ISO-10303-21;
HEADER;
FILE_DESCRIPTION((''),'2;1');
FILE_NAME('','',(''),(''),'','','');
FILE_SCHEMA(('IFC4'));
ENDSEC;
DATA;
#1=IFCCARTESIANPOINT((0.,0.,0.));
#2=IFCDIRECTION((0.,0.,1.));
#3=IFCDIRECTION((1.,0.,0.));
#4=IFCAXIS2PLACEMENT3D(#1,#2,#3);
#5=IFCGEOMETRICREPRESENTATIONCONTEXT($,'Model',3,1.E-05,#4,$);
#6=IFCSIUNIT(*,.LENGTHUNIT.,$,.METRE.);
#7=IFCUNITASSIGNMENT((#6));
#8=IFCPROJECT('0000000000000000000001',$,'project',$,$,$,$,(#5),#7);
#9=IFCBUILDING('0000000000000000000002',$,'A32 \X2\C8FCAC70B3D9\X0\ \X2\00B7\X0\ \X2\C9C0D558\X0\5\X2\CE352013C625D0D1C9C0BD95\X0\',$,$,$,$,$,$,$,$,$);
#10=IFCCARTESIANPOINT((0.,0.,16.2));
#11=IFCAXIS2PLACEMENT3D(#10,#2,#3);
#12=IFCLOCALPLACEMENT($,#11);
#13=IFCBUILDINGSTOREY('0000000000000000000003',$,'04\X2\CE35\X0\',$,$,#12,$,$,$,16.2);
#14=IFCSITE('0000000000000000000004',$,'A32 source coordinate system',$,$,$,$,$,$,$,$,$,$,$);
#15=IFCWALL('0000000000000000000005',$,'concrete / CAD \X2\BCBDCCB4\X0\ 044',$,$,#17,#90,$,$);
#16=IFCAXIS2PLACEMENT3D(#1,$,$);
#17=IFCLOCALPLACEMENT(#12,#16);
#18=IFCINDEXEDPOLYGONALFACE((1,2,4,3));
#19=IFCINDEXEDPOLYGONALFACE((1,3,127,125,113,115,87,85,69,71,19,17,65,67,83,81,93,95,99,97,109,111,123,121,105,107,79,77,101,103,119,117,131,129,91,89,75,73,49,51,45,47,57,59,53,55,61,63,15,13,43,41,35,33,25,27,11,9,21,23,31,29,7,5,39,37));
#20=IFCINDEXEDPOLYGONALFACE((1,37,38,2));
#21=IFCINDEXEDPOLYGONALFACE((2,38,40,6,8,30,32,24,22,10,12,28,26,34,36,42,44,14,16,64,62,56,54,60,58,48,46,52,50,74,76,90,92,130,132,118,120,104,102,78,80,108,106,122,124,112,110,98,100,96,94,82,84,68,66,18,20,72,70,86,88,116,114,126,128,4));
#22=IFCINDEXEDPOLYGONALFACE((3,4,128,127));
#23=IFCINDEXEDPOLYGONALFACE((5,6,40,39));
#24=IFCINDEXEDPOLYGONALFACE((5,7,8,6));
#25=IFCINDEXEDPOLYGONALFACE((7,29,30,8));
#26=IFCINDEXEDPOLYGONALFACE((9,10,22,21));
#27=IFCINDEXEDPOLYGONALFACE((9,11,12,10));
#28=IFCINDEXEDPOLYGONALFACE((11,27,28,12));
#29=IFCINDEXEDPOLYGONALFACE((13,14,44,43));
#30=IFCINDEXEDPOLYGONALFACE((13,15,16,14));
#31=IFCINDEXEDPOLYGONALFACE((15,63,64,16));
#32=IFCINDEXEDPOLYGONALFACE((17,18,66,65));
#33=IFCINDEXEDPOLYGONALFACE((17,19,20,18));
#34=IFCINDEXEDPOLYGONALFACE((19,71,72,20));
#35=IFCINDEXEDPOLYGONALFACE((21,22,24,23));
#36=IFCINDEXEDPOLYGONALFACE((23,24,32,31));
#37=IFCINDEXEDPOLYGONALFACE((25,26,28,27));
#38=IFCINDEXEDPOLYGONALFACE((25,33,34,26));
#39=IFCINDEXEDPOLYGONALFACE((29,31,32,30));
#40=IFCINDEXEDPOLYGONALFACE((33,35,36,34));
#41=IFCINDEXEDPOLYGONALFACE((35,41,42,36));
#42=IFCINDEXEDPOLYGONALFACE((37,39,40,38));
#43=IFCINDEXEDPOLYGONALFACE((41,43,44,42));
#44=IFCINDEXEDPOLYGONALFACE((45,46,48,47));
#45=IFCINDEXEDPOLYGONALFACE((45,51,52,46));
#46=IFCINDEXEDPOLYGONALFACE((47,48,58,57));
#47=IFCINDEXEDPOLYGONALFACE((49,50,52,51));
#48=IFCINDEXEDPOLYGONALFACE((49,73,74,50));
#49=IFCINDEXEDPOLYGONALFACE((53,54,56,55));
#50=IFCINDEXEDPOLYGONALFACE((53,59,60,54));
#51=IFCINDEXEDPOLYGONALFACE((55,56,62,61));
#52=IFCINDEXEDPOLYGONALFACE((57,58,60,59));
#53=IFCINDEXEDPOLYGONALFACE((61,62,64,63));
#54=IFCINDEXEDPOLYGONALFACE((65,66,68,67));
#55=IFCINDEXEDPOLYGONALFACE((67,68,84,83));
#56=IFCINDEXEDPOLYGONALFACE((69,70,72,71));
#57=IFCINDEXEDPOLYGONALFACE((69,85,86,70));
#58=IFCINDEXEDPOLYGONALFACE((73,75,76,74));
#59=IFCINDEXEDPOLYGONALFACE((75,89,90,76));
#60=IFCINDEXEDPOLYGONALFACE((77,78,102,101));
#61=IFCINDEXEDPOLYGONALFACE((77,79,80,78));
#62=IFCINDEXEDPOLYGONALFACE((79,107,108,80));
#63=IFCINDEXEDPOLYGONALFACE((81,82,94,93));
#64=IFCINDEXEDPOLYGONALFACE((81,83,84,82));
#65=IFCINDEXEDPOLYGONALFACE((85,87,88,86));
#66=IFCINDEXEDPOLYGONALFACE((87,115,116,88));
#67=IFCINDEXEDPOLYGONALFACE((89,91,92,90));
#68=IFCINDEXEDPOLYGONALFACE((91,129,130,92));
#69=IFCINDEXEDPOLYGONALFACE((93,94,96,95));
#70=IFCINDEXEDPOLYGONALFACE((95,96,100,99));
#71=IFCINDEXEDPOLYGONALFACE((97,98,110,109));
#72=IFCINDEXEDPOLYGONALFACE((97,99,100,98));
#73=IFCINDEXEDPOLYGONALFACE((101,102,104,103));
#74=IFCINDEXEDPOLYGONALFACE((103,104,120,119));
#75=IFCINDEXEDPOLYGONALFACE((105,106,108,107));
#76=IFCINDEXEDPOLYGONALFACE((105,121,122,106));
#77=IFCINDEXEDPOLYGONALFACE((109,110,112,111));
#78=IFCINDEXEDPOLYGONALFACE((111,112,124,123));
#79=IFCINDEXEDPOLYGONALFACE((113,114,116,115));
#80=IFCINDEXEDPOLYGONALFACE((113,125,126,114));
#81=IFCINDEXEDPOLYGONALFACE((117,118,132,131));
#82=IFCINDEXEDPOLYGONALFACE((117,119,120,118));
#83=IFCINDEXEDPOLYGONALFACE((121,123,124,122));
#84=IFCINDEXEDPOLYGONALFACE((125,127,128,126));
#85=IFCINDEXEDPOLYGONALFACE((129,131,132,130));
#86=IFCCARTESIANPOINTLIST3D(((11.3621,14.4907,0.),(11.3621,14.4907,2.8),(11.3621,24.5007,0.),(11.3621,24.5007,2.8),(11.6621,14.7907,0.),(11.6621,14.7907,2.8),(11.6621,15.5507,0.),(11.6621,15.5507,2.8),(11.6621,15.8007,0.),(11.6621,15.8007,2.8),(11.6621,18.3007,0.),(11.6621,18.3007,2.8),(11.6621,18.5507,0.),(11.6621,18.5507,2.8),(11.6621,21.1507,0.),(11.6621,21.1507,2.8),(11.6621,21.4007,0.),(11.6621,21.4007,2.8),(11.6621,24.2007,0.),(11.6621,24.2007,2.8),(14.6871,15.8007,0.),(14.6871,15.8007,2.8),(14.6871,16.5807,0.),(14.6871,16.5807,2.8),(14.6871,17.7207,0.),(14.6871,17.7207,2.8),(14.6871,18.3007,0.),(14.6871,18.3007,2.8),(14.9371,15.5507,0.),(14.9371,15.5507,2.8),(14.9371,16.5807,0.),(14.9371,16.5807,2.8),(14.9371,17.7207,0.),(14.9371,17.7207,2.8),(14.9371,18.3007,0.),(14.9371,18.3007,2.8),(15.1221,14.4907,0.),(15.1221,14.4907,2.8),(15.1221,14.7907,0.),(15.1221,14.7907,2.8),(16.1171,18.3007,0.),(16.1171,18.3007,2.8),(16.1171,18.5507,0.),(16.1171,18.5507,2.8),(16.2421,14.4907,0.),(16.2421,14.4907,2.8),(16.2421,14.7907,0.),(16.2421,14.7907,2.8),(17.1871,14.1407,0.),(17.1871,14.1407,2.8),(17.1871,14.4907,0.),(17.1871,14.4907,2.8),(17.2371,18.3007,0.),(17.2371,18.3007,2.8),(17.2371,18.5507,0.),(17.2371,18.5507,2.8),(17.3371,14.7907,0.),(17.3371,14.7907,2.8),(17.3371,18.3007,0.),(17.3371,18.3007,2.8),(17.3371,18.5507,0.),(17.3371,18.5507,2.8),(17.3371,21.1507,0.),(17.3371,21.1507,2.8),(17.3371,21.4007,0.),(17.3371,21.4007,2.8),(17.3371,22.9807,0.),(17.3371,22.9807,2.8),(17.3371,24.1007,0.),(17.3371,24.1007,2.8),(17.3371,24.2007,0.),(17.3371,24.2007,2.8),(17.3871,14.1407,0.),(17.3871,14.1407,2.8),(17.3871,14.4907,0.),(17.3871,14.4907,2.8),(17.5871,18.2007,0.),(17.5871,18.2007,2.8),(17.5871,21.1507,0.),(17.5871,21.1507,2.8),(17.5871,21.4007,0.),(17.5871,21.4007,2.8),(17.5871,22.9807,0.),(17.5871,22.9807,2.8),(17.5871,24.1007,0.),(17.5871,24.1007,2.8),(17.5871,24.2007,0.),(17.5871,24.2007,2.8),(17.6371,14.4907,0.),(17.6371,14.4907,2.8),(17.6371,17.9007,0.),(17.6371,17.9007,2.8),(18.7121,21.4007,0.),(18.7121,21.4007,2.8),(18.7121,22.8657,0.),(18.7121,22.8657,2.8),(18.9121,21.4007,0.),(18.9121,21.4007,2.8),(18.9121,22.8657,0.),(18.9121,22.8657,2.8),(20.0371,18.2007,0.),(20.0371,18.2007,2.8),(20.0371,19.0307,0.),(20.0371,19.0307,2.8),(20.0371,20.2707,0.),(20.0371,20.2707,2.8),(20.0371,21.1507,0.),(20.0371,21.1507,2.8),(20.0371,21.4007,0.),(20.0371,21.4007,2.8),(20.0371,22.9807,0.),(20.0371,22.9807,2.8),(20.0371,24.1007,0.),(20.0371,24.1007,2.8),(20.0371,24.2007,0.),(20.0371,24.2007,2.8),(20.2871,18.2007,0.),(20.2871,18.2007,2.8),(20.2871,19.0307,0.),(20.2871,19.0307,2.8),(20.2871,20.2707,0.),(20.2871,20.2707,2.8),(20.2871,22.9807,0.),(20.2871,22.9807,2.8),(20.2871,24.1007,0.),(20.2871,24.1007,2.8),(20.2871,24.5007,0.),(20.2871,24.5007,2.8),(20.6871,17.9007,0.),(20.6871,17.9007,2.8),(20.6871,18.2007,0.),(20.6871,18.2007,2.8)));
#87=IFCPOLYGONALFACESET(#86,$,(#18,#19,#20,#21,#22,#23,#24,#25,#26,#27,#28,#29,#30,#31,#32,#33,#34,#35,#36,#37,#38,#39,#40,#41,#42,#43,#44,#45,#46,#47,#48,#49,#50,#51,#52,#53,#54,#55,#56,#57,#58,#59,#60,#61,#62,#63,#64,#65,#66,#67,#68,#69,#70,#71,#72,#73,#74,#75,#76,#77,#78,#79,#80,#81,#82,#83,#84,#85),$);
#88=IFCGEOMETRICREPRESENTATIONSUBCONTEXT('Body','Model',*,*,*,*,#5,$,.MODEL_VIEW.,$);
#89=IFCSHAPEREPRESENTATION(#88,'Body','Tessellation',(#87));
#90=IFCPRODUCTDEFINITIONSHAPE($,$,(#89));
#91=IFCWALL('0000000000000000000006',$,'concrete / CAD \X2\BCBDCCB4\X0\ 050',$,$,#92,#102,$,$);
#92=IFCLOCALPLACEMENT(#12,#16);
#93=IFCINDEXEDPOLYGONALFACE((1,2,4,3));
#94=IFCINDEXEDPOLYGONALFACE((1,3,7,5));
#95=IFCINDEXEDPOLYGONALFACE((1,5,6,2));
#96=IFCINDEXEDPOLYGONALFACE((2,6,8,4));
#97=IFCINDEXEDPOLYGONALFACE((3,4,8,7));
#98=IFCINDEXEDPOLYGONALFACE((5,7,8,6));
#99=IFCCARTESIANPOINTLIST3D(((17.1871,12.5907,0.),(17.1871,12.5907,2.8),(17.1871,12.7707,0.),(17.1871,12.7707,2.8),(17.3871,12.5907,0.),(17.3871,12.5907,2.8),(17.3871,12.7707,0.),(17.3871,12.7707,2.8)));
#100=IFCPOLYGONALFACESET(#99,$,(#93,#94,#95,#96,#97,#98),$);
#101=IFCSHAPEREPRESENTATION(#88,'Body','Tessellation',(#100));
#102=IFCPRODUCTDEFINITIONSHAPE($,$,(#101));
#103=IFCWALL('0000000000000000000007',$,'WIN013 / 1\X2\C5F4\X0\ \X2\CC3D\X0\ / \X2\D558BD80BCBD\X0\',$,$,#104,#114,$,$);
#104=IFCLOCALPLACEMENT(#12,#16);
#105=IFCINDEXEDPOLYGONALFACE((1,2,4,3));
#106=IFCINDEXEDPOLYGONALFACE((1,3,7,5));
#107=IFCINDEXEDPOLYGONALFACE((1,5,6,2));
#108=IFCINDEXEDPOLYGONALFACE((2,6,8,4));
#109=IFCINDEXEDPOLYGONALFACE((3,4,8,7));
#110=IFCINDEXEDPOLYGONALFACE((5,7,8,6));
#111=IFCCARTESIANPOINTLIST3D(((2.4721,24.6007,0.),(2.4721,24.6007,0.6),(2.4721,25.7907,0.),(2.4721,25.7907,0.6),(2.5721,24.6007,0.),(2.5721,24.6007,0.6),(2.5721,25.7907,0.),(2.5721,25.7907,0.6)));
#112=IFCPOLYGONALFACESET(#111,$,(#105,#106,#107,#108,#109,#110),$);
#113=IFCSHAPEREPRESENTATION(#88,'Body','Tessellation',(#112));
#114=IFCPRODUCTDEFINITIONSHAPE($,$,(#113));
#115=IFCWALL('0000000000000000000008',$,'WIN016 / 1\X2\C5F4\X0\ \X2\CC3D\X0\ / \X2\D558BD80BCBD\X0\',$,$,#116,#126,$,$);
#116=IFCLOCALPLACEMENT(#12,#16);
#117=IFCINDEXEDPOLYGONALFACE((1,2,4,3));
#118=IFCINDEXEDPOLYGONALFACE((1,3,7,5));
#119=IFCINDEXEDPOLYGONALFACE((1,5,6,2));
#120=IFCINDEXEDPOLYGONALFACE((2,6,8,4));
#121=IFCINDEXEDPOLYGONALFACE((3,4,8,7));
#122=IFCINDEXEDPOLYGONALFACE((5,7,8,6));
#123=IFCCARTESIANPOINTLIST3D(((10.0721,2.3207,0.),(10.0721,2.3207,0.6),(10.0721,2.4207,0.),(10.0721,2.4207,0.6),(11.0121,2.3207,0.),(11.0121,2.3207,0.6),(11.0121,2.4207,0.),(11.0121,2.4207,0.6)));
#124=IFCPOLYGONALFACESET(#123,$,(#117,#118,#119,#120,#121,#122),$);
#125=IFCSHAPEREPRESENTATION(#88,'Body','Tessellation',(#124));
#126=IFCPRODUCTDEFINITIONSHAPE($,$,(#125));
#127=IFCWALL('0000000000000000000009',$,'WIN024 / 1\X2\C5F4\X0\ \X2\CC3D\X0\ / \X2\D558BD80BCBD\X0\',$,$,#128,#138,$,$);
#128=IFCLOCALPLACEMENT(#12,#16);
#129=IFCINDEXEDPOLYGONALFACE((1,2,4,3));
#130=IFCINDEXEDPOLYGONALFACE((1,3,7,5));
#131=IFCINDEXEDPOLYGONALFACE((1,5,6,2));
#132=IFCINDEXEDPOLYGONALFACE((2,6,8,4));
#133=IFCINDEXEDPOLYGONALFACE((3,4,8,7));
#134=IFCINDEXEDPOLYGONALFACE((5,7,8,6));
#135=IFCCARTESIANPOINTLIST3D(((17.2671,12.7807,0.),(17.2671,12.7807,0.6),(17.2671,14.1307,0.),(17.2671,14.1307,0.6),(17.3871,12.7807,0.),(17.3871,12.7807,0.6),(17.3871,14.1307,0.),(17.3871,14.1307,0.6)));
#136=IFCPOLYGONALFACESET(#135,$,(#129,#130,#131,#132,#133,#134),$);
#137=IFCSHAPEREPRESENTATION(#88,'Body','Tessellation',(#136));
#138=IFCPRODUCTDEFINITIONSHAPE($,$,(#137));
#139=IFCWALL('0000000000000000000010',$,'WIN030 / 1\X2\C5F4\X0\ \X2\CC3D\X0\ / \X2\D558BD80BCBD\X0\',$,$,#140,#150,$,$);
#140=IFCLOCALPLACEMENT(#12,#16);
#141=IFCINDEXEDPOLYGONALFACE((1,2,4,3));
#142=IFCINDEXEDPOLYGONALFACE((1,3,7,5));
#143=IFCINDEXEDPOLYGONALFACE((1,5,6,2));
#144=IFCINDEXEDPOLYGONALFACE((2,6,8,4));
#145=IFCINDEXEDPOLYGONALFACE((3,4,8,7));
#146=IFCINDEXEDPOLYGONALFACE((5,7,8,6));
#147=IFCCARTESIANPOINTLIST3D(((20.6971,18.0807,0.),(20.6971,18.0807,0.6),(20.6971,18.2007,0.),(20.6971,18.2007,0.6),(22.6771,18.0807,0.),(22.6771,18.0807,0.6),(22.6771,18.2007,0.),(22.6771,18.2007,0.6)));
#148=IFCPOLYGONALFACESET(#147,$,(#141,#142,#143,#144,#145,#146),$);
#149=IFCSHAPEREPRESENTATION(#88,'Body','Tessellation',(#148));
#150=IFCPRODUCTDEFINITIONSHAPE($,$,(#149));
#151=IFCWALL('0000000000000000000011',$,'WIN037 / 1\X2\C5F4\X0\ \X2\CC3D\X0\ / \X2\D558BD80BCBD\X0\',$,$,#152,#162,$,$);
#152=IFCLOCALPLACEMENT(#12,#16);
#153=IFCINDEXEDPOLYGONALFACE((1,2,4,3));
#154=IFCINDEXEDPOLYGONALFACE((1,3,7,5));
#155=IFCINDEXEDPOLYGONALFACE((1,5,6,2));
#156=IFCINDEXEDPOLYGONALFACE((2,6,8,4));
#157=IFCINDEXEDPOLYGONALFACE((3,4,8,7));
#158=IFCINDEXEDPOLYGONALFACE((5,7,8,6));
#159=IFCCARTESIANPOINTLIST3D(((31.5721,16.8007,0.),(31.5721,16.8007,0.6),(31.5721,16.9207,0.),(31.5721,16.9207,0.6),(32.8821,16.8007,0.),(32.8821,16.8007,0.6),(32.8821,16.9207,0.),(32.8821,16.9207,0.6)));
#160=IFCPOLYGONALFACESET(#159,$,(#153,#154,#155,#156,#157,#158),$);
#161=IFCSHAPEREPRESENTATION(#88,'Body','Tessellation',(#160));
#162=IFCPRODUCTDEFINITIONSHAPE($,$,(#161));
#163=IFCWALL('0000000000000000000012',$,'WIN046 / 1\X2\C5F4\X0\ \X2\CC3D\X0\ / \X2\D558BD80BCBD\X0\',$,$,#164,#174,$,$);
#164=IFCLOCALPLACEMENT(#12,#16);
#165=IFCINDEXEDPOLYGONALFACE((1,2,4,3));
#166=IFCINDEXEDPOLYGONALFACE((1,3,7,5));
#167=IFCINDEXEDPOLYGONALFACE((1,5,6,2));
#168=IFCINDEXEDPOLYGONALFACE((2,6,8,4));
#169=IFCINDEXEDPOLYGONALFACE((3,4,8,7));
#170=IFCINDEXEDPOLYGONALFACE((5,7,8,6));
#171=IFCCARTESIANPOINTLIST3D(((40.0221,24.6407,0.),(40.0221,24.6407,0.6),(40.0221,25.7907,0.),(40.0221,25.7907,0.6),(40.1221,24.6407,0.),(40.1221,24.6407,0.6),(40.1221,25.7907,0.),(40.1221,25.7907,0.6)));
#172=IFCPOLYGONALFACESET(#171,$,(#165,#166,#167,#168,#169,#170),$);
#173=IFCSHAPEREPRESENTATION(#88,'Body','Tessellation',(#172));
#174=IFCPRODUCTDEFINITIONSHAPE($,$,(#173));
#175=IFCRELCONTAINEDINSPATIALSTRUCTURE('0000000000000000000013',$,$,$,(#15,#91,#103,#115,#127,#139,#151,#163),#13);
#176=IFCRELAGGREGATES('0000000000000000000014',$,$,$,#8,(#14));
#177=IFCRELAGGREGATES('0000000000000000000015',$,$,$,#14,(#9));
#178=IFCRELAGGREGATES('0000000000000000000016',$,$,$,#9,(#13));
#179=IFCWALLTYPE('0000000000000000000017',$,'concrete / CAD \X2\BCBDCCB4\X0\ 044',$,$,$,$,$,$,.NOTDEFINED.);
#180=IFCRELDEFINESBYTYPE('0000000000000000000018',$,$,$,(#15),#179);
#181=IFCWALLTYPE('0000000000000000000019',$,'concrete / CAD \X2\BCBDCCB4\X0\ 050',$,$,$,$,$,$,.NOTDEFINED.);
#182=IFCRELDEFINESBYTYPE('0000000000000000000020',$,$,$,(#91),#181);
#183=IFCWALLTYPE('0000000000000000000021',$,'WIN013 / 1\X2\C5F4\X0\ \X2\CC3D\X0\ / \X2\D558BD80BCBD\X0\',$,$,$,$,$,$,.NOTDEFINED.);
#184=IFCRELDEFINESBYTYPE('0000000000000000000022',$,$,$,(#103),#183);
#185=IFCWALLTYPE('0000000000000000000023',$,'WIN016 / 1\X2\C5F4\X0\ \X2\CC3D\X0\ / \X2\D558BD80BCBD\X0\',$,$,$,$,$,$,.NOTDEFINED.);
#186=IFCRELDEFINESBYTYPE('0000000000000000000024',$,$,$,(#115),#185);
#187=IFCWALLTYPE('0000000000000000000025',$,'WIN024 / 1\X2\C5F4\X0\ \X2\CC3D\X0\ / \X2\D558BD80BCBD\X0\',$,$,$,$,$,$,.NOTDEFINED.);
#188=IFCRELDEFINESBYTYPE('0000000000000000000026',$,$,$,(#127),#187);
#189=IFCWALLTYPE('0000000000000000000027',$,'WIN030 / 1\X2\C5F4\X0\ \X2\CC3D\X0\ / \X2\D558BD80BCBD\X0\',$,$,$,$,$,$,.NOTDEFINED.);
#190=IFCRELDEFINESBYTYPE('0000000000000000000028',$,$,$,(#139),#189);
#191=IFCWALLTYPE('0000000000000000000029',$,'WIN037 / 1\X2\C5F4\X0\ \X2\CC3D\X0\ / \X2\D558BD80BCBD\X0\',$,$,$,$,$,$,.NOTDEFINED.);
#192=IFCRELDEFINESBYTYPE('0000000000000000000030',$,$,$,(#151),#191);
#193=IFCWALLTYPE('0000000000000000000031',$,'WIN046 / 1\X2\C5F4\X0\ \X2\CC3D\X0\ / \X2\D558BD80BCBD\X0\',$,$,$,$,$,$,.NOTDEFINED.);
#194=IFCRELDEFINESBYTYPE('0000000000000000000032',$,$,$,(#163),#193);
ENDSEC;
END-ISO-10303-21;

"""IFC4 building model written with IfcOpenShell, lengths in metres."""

from ifc_helpers import new_model, si_unit, frame, origin, origin_with_axes, place, context, subcontext, project, spatial, polyline, outline, extrude, source, transform, mapped, type_object, type_shapes, element, save


model = new_model("IFC4")

# Units and contexts
model_context = context("Model", 3, precision=1e-05, world=origin_with_axes())
body_context = subcontext(model_context, "Body", "Model", "MODEL_VIEW")
ifc_project = project(units=[si_unit("LENGTHUNIT", "METRE")], contexts=[model_context])

# Site, building, storey
site = spatial("IfcSite", under=ifc_project, Name="A32 source coordinate system")
building = spatial("IfcBuilding", under=site, Name="A32 주거동 · 지하5층–옥탑지붕")
storey_placement = place(None, frame((0.0, 0.0, 16.2), z_axis=(0.0, 0.0, 1.0), x_axis=(1.0, 0.0, 0.0)))
storey = spatial("IfcBuildingStorey", under=building, at=storey_placement, Name="04층", Elevation=16.2)

# Walls
wall_type_1 = type_object("IfcWallType", Name="concrete / CAD 벽체 044", PredefinedType="NOTDEFINED")
shared_shape_1 = source(origin(), body_context, "Body", "SweptSolid", [
    extrude(outline(polyline([(17.3371, 22.9807), (17.5871, 22.9807), (17.5871, 21.4007), (18.7121, 21.4007), (18.7121, 22.8657), (18.9121, 22.8657), (18.9121, 21.4007), (20.0371, 21.4007), (20.0371, 22.9807), (20.2871, 22.9807), (20.2871, 20.2707), (20.0371, 20.2707), (20.0371, 21.1507), (17.5871, 21.1507), (17.5871, 18.2007), (20.0371, 18.2007), (20.0371, 19.0307), (20.2871, 19.0307), (20.2871, 18.2007), (20.6871, 18.2007), (20.6871, 17.9007), (17.6371, 17.9007), (17.6371, 14.4907), (17.3871, 14.4907), (17.3871, 14.1407), (17.1871, 14.1407), (17.1871, 14.4907), (16.2421, 14.4907), (16.2421, 14.7907), (17.3371, 14.7907), (17.3371, 18.3007), (17.2371, 18.3007), (17.2371, 18.5507), (17.3371, 18.5507), (17.3371, 21.1507), (11.6621, 21.1507), (11.6621, 18.5507), (16.1171, 18.5507), (16.1171, 18.3007), (14.9371, 18.3007), (14.9371, 17.7207), (14.6871, 17.7207), (14.6871, 18.3007), (11.6621, 18.3007), (11.6621, 15.8007), (14.6871, 15.8007), (14.6871, 16.5807), (14.9371, 16.5807), (14.9371, 15.5507), (11.6621, 15.5507), (11.6621, 14.7907), (15.1221, 14.7907), (15.1221, 14.4907), (11.3621, 14.4907), (11.3621, 24.5007), (20.2871, 24.5007), (20.2871, 24.1007), (20.0371, 24.1007), (20.0371, 24.2007), (17.5871, 24.2007), (17.5871, 24.1007), (17.3371, 24.1007), (17.3371, 24.2007), (11.6621, 24.2007), (11.6621, 21.4007), (17.3371, 21.4007), (17.3371, 22.9807)])), origin(), (0.0, 0.0, 1.0), 2.8),
])
type_shapes(wall_type_1, [shared_shape_1])
wall_1_placement = place(storey_placement, origin_with_axes())
element("IfcWall", 1, at=wall_1_placement, inside=storey, type_object=wall_type_1, Name="concrete / CAD 벽체 044", context=body_context, shape_type="MappedRepresentation", body=[
    mapped(shared_shape_1, transform((0.0, 0.0, 0.0), scale=1.0)),
])
wall_type_2 = type_object("IfcWallType", Name="concrete / CAD 벽체 050", PredefinedType="NOTDEFINED")
shared_shape_2 = source(origin(), body_context, "Body", "SweptSolid", [
    extrude(outline(polyline([(17.1871, 12.5907), (17.1871, 12.7707), (17.3871, 12.7707), (17.3871, 12.5907), (17.1871, 12.5907)])), origin(), (0.0, 0.0, 1.0), 2.8),
])
type_shapes(wall_type_2, [shared_shape_2])
wall_2_placement = place(storey_placement, origin_with_axes())
element("IfcWall", 2, at=wall_2_placement, inside=storey, type_object=wall_type_2, Name="concrete / CAD 벽체 050", context=body_context, shape_type="MappedRepresentation", body=[
    mapped(shared_shape_2, transform((0.0, 0.0, 0.0), scale=1.0)),
])
wall_type_3 = type_object("IfcWallType", Name="WIN013 / 1열 창 / 하부벽", PredefinedType="NOTDEFINED")
shared_shape_3 = source(origin(), body_context, "Body", "SweptSolid", [
    extrude(outline(polyline([(2.5721, 25.7907), (2.5721, 24.6007), (2.4721, 24.6007), (2.4721, 25.7907), (2.5721, 25.7907)])), origin(), (0.0, 0.0, 1.0), 0.6),
])
type_shapes(wall_type_3, [shared_shape_3])
wall_3_placement = place(storey_placement, origin_with_axes())
element("IfcWall", 3, at=wall_3_placement, inside=storey, type_object=wall_type_3, Name="WIN013 / 1열 창 / 하부벽", context=body_context, shape_type="MappedRepresentation", body=[
    mapped(shared_shape_3, transform((0.0, 0.0, 0.0), scale=1.0)),
])
wall_type_4 = type_object("IfcWallType", Name="WIN016 / 1열 창 / 하부벽", PredefinedType="NOTDEFINED")
shared_shape_4 = source(origin(), body_context, "Body", "SweptSolid", [
    extrude(outline(polyline([(11.0121, 2.4207), (11.0121, 2.3207), (10.0721, 2.3207), (10.0721, 2.4207), (11.0121, 2.4207)])), origin(), (0.0, 0.0, 1.0), 0.6),
])
type_shapes(wall_type_4, [shared_shape_4])
wall_4_placement = place(storey_placement, origin_with_axes())
element("IfcWall", 4, at=wall_4_placement, inside=storey, type_object=wall_type_4, Name="WIN016 / 1열 창 / 하부벽", context=body_context, shape_type="MappedRepresentation", body=[
    mapped(shared_shape_4, transform((0.0, 0.0, 0.0), scale=1.0)),
])
wall_type_5 = type_object("IfcWallType", Name="WIN024 / 1열 창 / 하부벽", PredefinedType="NOTDEFINED")
shared_shape_5 = source(origin(), body_context, "Body", "SweptSolid", [
    extrude(outline(polyline([(17.3871, 14.1307), (17.3871, 12.7807), (17.2671, 12.7807), (17.2671, 14.1307), (17.3871, 14.1307)])), origin(), (0.0, 0.0, 1.0), 0.6),
])
type_shapes(wall_type_5, [shared_shape_5])
wall_5_placement = place(storey_placement, origin_with_axes())
element("IfcWall", 5, at=wall_5_placement, inside=storey, type_object=wall_type_5, Name="WIN024 / 1열 창 / 하부벽", context=body_context, shape_type="MappedRepresentation", body=[
    mapped(shared_shape_5, transform((0.0, 0.0, 0.0), scale=1.0)),
])
wall_type_6 = type_object("IfcWallType", Name="WIN030 / 1열 창 / 하부벽", PredefinedType="NOTDEFINED")
shared_shape_6 = source(origin(), body_context, "Body", "SweptSolid", [
    extrude(outline(polyline([(22.6771, 18.2007), (22.6771, 18.0807), (20.6971, 18.0807), (20.6971, 18.2007), (22.6771, 18.2007)])), origin(), (0.0, 0.0, 1.0), 0.6),
])
type_shapes(wall_type_6, [shared_shape_6])
wall_6_placement = place(storey_placement, origin_with_axes())
element("IfcWall", 6, at=wall_6_placement, inside=storey, type_object=wall_type_6, Name="WIN030 / 1열 창 / 하부벽", context=body_context, shape_type="MappedRepresentation", body=[
    mapped(shared_shape_6, transform((0.0, 0.0, 0.0), scale=1.0)),
])
wall_type_7 = type_object("IfcWallType", Name="WIN037 / 1열 창 / 하부벽", PredefinedType="NOTDEFINED")
shared_shape_7 = source(origin(), body_context, "Body", "SweptSolid", [
    extrude(outline(polyline([(32.8821, 16.9207), (32.8821, 16.8007), (31.5721, 16.8007), (31.5721, 16.9207), (32.8821, 16.9207)])), origin(), (0.0, 0.0, 1.0), 0.6),
])
type_shapes(wall_type_7, [shared_shape_7])
wall_7_placement = place(storey_placement, origin_with_axes())
element("IfcWall", 7, at=wall_7_placement, inside=storey, type_object=wall_type_7, Name="WIN037 / 1열 창 / 하부벽", context=body_context, shape_type="MappedRepresentation", body=[
    mapped(shared_shape_7, transform((0.0, 0.0, 0.0), scale=1.0)),
])
wall_type_8 = type_object("IfcWallType", Name="WIN046 / 1열 창 / 하부벽", PredefinedType="NOTDEFINED")
shared_shape_8 = source(origin(), body_context, "Body", "SweptSolid", [
    extrude(outline(polyline([(40.1221, 25.7907), (40.1221, 24.6407), (40.0221, 24.6407), (40.0221, 25.7907), (40.1221, 25.7907)])), origin(), (0.0, 0.0, 1.0), 0.6),
])
type_shapes(wall_type_8, [shared_shape_8])
wall_8_placement = place(storey_placement, origin_with_axes())
element("IfcWall", 8, at=wall_8_placement, inside=storey, type_object=wall_type_8, Name="WIN046 / 1열 창 / 하부벽", context=body_context, shape_type="MappedRepresentation", body=[
    mapped(shared_shape_8, transform((0.0, 0.0, 0.0), scale=1.0)),
])

save(model, "model.ifc")
